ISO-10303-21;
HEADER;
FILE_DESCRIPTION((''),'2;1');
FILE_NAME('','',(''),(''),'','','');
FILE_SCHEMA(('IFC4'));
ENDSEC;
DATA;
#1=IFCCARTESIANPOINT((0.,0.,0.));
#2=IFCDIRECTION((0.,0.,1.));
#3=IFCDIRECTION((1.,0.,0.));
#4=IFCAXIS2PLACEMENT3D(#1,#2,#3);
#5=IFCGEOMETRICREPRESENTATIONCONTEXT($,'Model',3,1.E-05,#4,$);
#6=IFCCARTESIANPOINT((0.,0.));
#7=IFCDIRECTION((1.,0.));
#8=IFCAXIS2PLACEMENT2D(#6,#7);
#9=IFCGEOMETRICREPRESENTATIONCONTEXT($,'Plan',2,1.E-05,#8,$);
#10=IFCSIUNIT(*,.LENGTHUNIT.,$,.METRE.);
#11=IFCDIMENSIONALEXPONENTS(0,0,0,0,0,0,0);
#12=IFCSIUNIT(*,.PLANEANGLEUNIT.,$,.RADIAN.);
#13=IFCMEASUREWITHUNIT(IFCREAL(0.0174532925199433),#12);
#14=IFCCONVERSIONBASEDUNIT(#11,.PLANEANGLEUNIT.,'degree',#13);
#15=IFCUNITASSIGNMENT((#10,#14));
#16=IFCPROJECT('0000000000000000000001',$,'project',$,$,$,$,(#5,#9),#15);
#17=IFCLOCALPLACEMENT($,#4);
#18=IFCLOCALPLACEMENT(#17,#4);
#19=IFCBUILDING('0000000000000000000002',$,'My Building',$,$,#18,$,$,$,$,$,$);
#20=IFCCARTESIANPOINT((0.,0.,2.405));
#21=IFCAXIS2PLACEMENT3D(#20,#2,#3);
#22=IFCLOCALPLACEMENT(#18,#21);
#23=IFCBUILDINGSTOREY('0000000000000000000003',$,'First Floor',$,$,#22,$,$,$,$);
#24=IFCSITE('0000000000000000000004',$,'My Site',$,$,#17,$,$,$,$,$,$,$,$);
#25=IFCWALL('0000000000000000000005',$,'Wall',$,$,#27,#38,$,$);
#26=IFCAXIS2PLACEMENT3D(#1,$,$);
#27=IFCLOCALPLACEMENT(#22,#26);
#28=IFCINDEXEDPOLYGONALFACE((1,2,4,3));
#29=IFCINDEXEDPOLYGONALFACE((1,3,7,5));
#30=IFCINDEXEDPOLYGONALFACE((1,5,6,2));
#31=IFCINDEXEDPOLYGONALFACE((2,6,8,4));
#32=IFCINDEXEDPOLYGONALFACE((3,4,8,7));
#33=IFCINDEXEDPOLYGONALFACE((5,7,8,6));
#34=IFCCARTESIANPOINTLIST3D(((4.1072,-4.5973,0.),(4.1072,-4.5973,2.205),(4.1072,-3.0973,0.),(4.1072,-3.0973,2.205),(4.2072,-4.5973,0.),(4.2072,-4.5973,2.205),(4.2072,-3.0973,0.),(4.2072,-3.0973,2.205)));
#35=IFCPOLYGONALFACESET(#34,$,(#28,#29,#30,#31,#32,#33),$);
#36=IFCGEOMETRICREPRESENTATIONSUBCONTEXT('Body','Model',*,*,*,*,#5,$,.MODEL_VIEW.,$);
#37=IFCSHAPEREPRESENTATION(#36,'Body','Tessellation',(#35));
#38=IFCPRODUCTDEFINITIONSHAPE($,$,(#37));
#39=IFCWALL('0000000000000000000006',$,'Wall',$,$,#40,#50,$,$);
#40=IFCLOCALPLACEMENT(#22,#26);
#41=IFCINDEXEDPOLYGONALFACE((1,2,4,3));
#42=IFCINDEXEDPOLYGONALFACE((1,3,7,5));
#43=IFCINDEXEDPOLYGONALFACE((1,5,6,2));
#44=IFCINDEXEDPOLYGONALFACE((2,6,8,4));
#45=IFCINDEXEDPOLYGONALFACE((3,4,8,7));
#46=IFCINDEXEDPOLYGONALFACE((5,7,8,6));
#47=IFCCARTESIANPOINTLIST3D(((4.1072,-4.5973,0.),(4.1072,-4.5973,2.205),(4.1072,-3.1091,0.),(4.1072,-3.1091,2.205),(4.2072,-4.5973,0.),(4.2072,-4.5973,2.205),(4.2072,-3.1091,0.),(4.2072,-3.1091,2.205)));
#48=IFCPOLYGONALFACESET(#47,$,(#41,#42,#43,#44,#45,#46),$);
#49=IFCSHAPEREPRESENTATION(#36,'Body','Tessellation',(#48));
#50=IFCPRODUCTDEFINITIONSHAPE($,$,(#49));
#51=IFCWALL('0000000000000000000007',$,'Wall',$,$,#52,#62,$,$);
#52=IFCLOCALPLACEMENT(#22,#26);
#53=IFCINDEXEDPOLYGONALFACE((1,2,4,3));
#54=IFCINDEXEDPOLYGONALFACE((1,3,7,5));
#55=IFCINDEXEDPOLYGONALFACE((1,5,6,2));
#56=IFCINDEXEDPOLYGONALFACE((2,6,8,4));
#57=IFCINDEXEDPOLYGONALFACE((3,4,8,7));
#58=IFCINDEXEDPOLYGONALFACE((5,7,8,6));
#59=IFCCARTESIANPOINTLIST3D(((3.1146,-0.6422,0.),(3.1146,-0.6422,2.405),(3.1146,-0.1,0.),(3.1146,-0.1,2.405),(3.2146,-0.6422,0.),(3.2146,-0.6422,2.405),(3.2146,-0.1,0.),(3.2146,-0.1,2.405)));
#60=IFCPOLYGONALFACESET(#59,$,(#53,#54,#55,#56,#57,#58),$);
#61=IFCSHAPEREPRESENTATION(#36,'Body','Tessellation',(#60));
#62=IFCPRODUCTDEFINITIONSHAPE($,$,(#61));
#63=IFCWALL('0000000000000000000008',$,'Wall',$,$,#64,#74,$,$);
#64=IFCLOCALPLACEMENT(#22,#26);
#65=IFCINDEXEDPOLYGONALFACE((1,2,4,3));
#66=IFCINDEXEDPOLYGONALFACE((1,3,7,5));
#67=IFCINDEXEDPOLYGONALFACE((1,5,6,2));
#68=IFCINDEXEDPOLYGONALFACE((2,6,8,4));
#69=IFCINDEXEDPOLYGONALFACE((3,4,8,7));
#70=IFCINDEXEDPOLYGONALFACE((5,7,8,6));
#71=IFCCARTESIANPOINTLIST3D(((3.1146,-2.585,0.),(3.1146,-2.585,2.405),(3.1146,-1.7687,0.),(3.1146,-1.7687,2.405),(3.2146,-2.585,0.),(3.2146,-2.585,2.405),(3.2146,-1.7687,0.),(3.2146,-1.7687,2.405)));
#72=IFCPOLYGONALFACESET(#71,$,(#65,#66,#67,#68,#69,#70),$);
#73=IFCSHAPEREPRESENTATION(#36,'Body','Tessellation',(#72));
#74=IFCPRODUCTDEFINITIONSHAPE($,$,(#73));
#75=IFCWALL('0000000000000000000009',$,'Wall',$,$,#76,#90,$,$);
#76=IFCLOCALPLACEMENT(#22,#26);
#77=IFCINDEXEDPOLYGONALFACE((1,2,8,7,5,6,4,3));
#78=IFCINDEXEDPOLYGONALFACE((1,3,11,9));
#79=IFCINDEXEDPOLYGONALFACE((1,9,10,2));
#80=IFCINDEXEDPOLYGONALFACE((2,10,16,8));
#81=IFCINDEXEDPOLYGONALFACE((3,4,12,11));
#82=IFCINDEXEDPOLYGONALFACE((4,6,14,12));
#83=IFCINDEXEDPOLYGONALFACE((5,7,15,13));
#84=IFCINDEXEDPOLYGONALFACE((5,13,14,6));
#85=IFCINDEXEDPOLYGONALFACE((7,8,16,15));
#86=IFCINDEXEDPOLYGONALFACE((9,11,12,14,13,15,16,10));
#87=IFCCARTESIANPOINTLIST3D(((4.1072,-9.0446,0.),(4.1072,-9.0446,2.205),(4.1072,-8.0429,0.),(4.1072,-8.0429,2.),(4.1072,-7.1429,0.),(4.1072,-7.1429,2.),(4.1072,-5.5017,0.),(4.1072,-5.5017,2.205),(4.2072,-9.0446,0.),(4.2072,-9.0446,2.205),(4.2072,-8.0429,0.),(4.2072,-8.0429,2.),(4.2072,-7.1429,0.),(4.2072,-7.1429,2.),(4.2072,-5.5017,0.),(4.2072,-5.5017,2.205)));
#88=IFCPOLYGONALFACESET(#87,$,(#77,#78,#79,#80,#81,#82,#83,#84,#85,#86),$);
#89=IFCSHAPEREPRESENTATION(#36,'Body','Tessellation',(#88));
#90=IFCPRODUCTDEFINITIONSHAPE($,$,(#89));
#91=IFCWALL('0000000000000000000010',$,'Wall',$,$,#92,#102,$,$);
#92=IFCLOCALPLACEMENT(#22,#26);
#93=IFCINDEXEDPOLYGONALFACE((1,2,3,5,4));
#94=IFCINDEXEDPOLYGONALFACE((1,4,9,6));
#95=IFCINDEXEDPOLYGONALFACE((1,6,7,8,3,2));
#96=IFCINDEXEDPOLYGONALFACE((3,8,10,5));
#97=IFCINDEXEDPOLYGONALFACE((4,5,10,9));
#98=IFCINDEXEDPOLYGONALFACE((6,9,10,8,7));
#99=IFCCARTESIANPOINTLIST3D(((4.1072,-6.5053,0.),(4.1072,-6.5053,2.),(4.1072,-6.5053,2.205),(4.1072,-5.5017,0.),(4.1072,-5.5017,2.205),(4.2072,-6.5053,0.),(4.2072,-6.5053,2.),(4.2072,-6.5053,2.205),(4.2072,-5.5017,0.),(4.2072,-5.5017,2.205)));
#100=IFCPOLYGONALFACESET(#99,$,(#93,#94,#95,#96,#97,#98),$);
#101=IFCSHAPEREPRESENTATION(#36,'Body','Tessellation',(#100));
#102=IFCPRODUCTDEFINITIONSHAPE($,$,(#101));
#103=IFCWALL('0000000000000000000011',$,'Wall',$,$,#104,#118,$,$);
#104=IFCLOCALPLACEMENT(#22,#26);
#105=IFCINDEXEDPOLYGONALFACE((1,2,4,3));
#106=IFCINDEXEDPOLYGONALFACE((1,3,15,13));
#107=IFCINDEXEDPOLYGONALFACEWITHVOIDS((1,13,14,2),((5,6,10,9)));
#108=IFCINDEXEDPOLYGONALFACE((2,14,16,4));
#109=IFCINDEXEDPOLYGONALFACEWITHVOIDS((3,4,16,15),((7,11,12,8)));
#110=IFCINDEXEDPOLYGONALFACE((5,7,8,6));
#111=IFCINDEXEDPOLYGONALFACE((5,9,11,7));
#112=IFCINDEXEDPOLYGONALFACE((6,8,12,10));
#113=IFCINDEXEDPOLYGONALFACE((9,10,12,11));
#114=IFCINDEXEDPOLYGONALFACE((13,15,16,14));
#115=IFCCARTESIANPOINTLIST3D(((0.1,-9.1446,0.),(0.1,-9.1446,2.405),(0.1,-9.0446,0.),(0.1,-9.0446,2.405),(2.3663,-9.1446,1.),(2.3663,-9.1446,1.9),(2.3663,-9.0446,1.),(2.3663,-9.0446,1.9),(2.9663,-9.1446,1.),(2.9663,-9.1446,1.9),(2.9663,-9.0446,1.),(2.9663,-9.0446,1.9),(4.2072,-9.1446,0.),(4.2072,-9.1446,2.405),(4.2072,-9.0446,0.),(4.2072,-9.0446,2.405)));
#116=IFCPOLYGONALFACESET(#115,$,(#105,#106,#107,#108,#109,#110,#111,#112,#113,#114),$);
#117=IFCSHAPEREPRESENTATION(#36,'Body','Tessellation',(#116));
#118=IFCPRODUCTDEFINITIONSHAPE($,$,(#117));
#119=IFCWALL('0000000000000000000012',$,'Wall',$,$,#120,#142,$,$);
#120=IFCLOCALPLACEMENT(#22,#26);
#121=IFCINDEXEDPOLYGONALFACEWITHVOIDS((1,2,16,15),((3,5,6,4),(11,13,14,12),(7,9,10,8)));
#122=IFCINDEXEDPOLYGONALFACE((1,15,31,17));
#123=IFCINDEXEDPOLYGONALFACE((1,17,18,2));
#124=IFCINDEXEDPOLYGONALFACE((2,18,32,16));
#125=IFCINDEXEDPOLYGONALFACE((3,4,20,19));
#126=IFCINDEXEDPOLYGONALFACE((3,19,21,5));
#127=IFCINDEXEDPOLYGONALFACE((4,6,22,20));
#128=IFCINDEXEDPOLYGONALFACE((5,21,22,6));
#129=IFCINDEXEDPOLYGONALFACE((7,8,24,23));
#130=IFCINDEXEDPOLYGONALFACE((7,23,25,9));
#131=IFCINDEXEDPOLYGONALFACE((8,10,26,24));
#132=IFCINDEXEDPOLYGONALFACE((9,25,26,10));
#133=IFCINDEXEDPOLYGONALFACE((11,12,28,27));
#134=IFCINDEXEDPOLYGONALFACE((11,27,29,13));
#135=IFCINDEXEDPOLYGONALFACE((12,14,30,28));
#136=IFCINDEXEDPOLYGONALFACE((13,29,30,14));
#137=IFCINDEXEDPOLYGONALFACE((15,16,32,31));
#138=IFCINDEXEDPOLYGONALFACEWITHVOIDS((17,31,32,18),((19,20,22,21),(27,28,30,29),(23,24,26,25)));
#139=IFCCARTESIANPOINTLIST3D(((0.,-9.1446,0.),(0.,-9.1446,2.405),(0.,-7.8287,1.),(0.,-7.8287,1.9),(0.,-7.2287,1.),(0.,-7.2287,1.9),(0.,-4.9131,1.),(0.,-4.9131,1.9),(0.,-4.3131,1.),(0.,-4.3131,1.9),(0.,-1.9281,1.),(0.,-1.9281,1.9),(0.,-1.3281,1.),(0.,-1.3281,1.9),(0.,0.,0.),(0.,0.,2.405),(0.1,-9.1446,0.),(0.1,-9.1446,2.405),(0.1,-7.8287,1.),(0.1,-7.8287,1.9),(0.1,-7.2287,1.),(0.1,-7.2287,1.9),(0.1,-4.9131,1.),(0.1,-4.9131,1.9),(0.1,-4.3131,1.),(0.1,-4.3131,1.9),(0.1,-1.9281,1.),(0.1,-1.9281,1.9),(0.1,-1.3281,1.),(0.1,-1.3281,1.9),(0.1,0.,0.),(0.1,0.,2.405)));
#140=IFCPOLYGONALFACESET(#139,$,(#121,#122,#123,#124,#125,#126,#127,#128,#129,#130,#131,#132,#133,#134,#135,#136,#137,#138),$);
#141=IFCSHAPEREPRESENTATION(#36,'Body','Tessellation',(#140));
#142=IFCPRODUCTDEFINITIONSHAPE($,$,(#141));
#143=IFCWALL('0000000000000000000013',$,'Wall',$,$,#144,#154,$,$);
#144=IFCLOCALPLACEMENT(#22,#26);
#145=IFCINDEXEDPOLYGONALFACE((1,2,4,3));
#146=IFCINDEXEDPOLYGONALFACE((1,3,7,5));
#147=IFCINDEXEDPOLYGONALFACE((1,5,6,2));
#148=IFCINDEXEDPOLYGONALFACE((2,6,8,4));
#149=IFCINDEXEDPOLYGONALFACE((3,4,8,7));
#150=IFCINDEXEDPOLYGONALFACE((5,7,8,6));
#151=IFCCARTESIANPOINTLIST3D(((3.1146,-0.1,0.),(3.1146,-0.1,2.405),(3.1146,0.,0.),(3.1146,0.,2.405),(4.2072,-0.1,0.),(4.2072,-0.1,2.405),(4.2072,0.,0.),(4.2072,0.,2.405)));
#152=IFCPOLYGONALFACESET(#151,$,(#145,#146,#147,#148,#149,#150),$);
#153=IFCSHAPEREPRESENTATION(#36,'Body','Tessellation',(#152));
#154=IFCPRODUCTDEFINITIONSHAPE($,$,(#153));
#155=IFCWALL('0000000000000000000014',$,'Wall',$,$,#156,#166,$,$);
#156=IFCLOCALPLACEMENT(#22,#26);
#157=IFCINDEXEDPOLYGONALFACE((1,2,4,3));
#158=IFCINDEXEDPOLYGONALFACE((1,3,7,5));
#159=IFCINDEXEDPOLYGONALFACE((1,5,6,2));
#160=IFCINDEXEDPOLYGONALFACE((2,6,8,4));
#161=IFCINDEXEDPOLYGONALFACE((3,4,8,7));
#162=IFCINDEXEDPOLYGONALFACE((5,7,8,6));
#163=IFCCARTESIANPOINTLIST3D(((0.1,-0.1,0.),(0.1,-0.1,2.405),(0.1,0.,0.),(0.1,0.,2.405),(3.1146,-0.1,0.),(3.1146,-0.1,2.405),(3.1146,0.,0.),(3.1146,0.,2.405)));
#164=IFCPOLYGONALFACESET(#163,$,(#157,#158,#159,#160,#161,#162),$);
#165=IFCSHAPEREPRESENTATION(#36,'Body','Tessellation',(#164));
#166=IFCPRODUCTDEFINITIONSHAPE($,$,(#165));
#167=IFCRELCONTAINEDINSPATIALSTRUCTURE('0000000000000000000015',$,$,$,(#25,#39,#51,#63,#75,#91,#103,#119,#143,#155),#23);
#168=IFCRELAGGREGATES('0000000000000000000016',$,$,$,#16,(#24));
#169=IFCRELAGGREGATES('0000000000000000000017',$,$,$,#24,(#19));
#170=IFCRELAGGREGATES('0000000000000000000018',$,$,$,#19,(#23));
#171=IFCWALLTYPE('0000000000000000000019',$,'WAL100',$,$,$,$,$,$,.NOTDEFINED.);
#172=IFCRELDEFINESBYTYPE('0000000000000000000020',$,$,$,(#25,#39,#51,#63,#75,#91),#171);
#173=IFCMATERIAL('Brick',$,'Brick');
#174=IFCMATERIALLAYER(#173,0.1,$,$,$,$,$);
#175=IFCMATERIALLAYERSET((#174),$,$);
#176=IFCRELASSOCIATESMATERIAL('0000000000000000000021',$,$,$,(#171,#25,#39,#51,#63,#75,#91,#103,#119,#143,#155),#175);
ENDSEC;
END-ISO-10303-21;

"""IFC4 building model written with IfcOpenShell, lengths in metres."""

from ifc_helpers import new_model, entity, si_unit, converted_unit, frame, origin_with_axes, origin_2d_with_axis, place, context, subcontext, project, spatial, line, indexed_curve, outline, extrude, source, transform, mapped, material, layer, layer_set, layer_usage, type_object, element, save


model = new_model("IFC4")

# Units and contexts
model_context = context("Model", 3, precision=1e-05, world=origin_with_axes())
plan_context = context("Plan", 2, precision=1e-05, world=origin_2d_with_axis())
body_context = subcontext(model_context, "Body", "Model", "MODEL_VIEW")
ifc_project = project(units=[si_unit("LENGTHUNIT", "METRE"), converted_unit("PLANEANGLEUNIT", "degree", entity("IfcReal", 0.0174532925199433), si_unit("PLANEANGLEUNIT", "RADIAN"), dimensions=[0, 0, 0, 0, 0, 0, 0])], contexts=[model_context, plan_context])

# Site, building, storey
site_placement = place(None, origin_with_axes())
site = spatial("IfcSite", under=ifc_project, at=site_placement, Name="My Site")
building_placement = place(site_placement, origin_with_axes())
building = spatial("IfcBuilding", under=site, at=building_placement, Name="My Building")
storey_placement = place(building_placement, frame((0.0, 0.0, 2.405), z_axis=(0.0, 0.0, 1.0), x_axis=(1.0, 0.0, 0.0)))
storey = spatial("IfcBuildingStorey", under=building, at=storey_placement, Name="First Floor")

# Walls
ifc_material_1 = material(Name="Brick", Category="Brick")
ifc_layer_1 = layer(ifc_material_1, 0.1)
ifc_layer_set_1 = layer_set([ifc_layer_1])
wall_type = type_object("IfcWallType", Name="WAL100", PredefinedType="NOTDEFINED", material=ifc_layer_set_1)
ifc_layer_usage_1 = layer_usage(ifc_layer_set_1, "AXIS2", "POSITIVE", 0.0)
wall_1_placement = place(storey_placement, frame((4.1072, -3.0973, 0.0), z_axis=(0.0, 0.0, 1.0), x_axis=(-0.000001, -1.0, 0.0)))
element("IfcWall", 1, at=wall_1_placement, inside=storey, type_object=wall_type, material=ifc_layer_usage_1, Name="Wall", context=body_context, shape_type="SweptSolid", body=[
    extrude(outline(indexed_curve([(0.0, 0.0), (0.0, 0.1), (1.5, 0.1), (1.5, 0.0), (0.0, 0.0)], self_intersect=False)), origin_with_axes(), (0.0, 0.0, 1.0), 2.205),
])
ifc_layer_usage_2 = layer_usage(ifc_layer_set_1, "AXIS2", "POSITIVE", 0.0)
wall_2_placement = place(storey_placement, frame((4.1072, -3.1091, 0.0), z_axis=(0.0, 0.0, 1.0), x_axis=(-0.000001, -1.0, 0.0)))
element("IfcWall", 2, at=wall_2_placement, inside=storey, type_object=wall_type, material=ifc_layer_usage_2, Name="Wall", context=body_context, shape_type="SweptSolid", body=[
    extrude(outline(indexed_curve([(0.0, 0.0), (0.0, 0.1), (1.4882, 0.1), (1.4882, 0.0), (0.0, 0.0)], self_intersect=False)), origin_with_axes(), (0.0, 0.0, 1.0), 2.205),
])
ifc_layer_usage_3 = layer_usage(ifc_layer_set_1, "AXIS2", "POSITIVE", 0.0)
wall_3_placement = place(storey_placement, frame((3.1146, -0.1, 0.0), z_axis=(0.0, 0.0, 1.0), x_axis=(-0.000001, -1.0, 0.0)))
element("IfcWall", 3, at=wall_3_placement, inside=storey, type_object=wall_type, material=ifc_layer_usage_3, Name="Wall", context=body_context, shape_type="SweptSolid", body=[
    extrude(outline(indexed_curve([(0.0, 0.0), (0.0, 0.1), (0.5422, 0.1), (0.5422, 0.0), (0.0, 0.0)], self_intersect=False)), origin_with_axes(), (0.0, 0.0, 1.0), 2.405),
])
ifc_layer_usage_4 = layer_usage(ifc_layer_set_1, "AXIS2", "POSITIVE", 0.0)
wall_4_placement = place(storey_placement, frame((3.1146, -1.7687, 0.0), z_axis=(0.0, 0.0, 1.0), x_axis=(-0.000001, -1.0, 0.0)))
element("IfcWall", 4, at=wall_4_placement, inside=storey, type_object=wall_type, material=ifc_layer_usage_4, Name="Wall", context=body_context, shape_type="SweptSolid", body=[
    extrude(outline(indexed_curve([(0.0, 0.0), (0.0, 0.1), (0.8163, 0.1), (0.8163, 0.0), (0.0, 0.0)], self_intersect=False)), origin_with_axes(), (0.0, 0.0, 1.0), 2.405),
])

# Walls, openings
ifc_layer_usage_5 = layer_usage(ifc_layer_set_1, "AXIS2", "POSITIVE", 0.0)
wall_5_placement = place(storey_placement, frame((4.1072, -5.5017, 0.0), z_axis=(0.0, 0.0, 1.0), x_axis=(-0.000001, -1.0, 0.0)))
wall_5 = element("IfcWall", 5, at=wall_5_placement, inside=storey, type_object=wall_type, material=ifc_layer_usage_5, Name="Wall", context=body_context, shape_type="SweptSolid", body=[
    extrude(outline(indexed_curve([(0.0, 0.0), (0.0, 0.1), (3.543, 0.1), (3.543, 0.0), (0.0, 0.0)], self_intersect=False)), origin_with_axes(), (0.0, 0.0, 1.0), 2.205),
])
shared_shape_1 = source(origin_with_axes(), body_context, "Body", "SweptSolid", [
    extrude(outline(indexed_curve([(0.0, 0.0), (0.9, 0.0), (0.9, 2.0), (0.0, 2.0)], segments=[line(1, 2, 3, 4, 1)])), frame((0.0, -0.1, 0.0), z_axis=(0.0, -1.0, 0.0), x_axis=(1.0, 0.0, 0.0)), (0.0, 0.0, -1.0), 0.3),
])
opening_1_placement = place(wall_5_placement, frame((1.6412, 0.0, 0.0), z_axis=(0.0, 0.0, 1.0), x_axis=(1.0, 0.0, 0.0)))
element("IfcOpeningElement", 6, at=opening_1_placement, cuts=wall_5, PredefinedType="OPENING", context=body_context, shape_type="MappedRepresentation", body=[
    mapped(shared_shape_1, transform((0.0, 0.0, 0.0), x_axis=(1.0, 0.0, 0.0), y_axis=(0.0, 1.0, 0.0), z_axis=(0.0, 0.0, 1.0), scale=1.0)),
])
ifc_layer_usage_6 = layer_usage(ifc_layer_set_1, "AXIS2", "POSITIVE", 0.0)
wall_6_placement = place(storey_placement, frame((4.1072, -5.5017, 0.0), z_axis=(0.0, 0.0, 1.0), x_axis=(-0.000001, -1.0, 0.0)))
wall_6 = element("IfcWall", 7, at=wall_6_placement, inside=storey, type_object=wall_type, material=ifc_layer_usage_6, Name="Wall", context=body_context, shape_type="SweptSolid", body=[
    extrude(outline(indexed_curve([(0.0, 0.0), (0.0, 0.1), (1.0036, 0.1), (1.0036, 0.0), (0.0, 0.0)], self_intersect=False)), origin_with_axes(), (0.0, 0.0, 1.0), 2.205),
])
opening_2_placement = place(wall_6_placement, frame((1.0036, 0.0, 0.0), z_axis=(0.0, 0.0, 1.0), x_axis=(1.0, 0.0, 0.0)))
element("IfcOpeningElement", 8, at=opening_2_placement, cuts=wall_6, PredefinedType="OPENING", context=body_context, shape_type="MappedRepresentation", body=[
    mapped(shared_shape_1, transform((0.0, 0.0, 0.0), x_axis=(1.0, 0.0, 0.0), y_axis=(0.0, 1.0, 0.0), z_axis=(0.0, 0.0, 1.0), scale=1.0)),
])
ifc_layer_usage_7 = layer_usage(ifc_layer_set_1, "AXIS2", "POSITIVE", 0.0)
wall_7_placement = place(storey_placement, frame((0.1, -9.1446, 0.0), z_axis=(0.0, 0.0, 1.0), x_axis=(1.0, 0.0, 0.0)))
wall_7 = element("IfcWall", 9, at=wall_7_placement, inside=storey, material=ifc_layer_usage_7, Name="Wall", context=body_context, shape_type="SweptSolid", body=[
    extrude(outline(indexed_curve([(0.0, 0.0), (0.0, 0.1), (4.1072, 0.1), (4.1072, 0.0), (0.0, 0.0)], self_intersect=False)), origin_with_axes(), (0.0, 0.0, 1.0), 2.405),
])
shared_shape_2 = source(origin_with_axes(), body_context, "Body", "SweptSolid", [
    extrude(outline(indexed_curve([(0.0, 0.0), (0.6, 0.0), (0.6, 0.9), (0.0, 0.9)], segments=[line(1, 2, 3, 4, 1)])), frame((0.0, -0.1, 0.0), z_axis=(0.0, -1.0, 0.0), x_axis=(1.0, 0.0, 0.0)), (0.0, 0.0, -1.0), 0.3),
])
opening_3_placement = place(wall_7_placement, frame((2.2663, 0.0, 1.0), z_axis=(0.0, 0.0, 1.0), x_axis=(1.0, 0.0, 0.0)))
element("IfcOpeningElement", 10, at=opening_3_placement, cuts=wall_7, PredefinedType="OPENING", context=body_context, shape_type="MappedRepresentation", body=[
    mapped(shared_shape_2, transform((0.0, 0.0, 0.0), x_axis=(1.0, 0.0, 0.0), y_axis=(0.0, 1.0, 0.0), z_axis=(0.0, 0.0, 1.0), scale=1.0)),
])

# Wall, openings
ifc_layer_usage_8 = layer_usage(ifc_layer_set_1, "AXIS2", "POSITIVE", 0.0)
wall_8_placement = place(storey_placement, frame((0.0, 0.0, 0.0), z_axis=(0.0, 0.0, 1.0), x_axis=(-0.000001, -1.0, 0.0)))
wall_8 = element("IfcWall", 11, at=wall_8_placement, inside=storey, material=ifc_layer_usage_8, Name="Wall", context=body_context, shape_type="SweptSolid", body=[
    extrude(outline(indexed_curve([(0.0, 0.0), (0.0, 0.1), (9.1446, 0.1), (9.1446, 0.0), (0.0, 0.0)], self_intersect=False)), origin_with_axes(), (0.0, 0.0, 1.0), 2.405),
])
opening_4_placement = place(wall_8_placement, frame((7.2287, -0.05, 1.0), z_axis=(0.0, 0.0, 1.0), x_axis=(1.0, 0.0, 0.0)))
element("IfcOpeningElement", 12, at=opening_4_placement, cuts=wall_8, PredefinedType="OPENING", context=body_context, shape_type="MappedRepresentation", body=[
    mapped(shared_shape_2, transform((0.0, 0.0, 0.0), x_axis=(1.0, 0.0, 0.0), y_axis=(0.0, 1.0, 0.0), z_axis=(0.0, 0.0, 1.0), scale=1.0)),
])
opening_5_placement = place(wall_8_placement, frame((4.3131, 0.0, 1.0), z_axis=(0.0, 0.0, 1.0), x_axis=(1.0, 0.0, 0.0)))
element("IfcOpeningElement", 13, at=opening_5_placement, cuts=wall_8, PredefinedType="OPENING", context=body_context, shape_type="MappedRepresentation", body=[
    mapped(shared_shape_2, transform((0.0, 0.0, 0.0), x_axis=(1.0, 0.0, 0.0), y_axis=(0.0, 1.0, 0.0), z_axis=(0.0, 0.0, 1.0), scale=1.0)),
])
opening_6_placement = place(wall_8_placement, frame((1.3281, 0.0, 1.0), z_axis=(0.0, 0.0, 1.0), x_axis=(1.0, 0.0, 0.0)))
element("IfcOpeningElement", 14, at=opening_6_placement, cuts=wall_8, PredefinedType="OPENING", context=body_context, shape_type="MappedRepresentation", body=[
    mapped(shared_shape_2, transform((0.0, 0.0, 0.0), x_axis=(1.0, 0.0, 0.0), y_axis=(0.0, 1.0, 0.0), z_axis=(0.0, 0.0, 1.0), scale=1.0)),
])

# Walls
ifc_layer_usage_9 = layer_usage(ifc_layer_set_1, "AXIS2", "POSITIVE", 0.0)
wall_9_placement = place(storey_placement, frame((4.2072, 0.0, 0.0), z_axis=(0.0, 0.0, 1.0), x_axis=(-1.0, 0.000001, 0.0)))
element("IfcWall", 15, at=wall_9_placement, inside=storey, material=ifc_layer_usage_9, Name="Wall", context=body_context, shape_type="SweptSolid", body=[
    extrude(outline(indexed_curve([(0.0, 0.0), (0.0, 0.1), (1.0925, 0.1), (1.0925, 0.0), (0.0, 0.0)], self_intersect=False)), origin_with_axes(), (0.0, 0.0, 1.0), 2.405),
])
ifc_layer_usage_10 = layer_usage(ifc_layer_set_1, "AXIS2", "POSITIVE", 0.0)
wall_10_placement = place(storey_placement, frame((3.1146, 0.0, 0.0), z_axis=(0.0, 0.0, 1.0), x_axis=(-1.0, 0.0, 0.0)))
element("IfcWall", 16, at=wall_10_placement, inside=storey, material=ifc_layer_usage_10, Name="Wall", context=body_context, shape_type="SweptSolid", body=[
    extrude(outline(indexed_curve([(0.0, 0.0), (0.0, 0.1), (3.0146, 0.1), (3.0146, 0.0), (0.0, 0.0)], self_intersect=False)), origin_with_axes(), (0.0, 0.0, 1.0), 2.405),
])

save(model, "model.ifc")
